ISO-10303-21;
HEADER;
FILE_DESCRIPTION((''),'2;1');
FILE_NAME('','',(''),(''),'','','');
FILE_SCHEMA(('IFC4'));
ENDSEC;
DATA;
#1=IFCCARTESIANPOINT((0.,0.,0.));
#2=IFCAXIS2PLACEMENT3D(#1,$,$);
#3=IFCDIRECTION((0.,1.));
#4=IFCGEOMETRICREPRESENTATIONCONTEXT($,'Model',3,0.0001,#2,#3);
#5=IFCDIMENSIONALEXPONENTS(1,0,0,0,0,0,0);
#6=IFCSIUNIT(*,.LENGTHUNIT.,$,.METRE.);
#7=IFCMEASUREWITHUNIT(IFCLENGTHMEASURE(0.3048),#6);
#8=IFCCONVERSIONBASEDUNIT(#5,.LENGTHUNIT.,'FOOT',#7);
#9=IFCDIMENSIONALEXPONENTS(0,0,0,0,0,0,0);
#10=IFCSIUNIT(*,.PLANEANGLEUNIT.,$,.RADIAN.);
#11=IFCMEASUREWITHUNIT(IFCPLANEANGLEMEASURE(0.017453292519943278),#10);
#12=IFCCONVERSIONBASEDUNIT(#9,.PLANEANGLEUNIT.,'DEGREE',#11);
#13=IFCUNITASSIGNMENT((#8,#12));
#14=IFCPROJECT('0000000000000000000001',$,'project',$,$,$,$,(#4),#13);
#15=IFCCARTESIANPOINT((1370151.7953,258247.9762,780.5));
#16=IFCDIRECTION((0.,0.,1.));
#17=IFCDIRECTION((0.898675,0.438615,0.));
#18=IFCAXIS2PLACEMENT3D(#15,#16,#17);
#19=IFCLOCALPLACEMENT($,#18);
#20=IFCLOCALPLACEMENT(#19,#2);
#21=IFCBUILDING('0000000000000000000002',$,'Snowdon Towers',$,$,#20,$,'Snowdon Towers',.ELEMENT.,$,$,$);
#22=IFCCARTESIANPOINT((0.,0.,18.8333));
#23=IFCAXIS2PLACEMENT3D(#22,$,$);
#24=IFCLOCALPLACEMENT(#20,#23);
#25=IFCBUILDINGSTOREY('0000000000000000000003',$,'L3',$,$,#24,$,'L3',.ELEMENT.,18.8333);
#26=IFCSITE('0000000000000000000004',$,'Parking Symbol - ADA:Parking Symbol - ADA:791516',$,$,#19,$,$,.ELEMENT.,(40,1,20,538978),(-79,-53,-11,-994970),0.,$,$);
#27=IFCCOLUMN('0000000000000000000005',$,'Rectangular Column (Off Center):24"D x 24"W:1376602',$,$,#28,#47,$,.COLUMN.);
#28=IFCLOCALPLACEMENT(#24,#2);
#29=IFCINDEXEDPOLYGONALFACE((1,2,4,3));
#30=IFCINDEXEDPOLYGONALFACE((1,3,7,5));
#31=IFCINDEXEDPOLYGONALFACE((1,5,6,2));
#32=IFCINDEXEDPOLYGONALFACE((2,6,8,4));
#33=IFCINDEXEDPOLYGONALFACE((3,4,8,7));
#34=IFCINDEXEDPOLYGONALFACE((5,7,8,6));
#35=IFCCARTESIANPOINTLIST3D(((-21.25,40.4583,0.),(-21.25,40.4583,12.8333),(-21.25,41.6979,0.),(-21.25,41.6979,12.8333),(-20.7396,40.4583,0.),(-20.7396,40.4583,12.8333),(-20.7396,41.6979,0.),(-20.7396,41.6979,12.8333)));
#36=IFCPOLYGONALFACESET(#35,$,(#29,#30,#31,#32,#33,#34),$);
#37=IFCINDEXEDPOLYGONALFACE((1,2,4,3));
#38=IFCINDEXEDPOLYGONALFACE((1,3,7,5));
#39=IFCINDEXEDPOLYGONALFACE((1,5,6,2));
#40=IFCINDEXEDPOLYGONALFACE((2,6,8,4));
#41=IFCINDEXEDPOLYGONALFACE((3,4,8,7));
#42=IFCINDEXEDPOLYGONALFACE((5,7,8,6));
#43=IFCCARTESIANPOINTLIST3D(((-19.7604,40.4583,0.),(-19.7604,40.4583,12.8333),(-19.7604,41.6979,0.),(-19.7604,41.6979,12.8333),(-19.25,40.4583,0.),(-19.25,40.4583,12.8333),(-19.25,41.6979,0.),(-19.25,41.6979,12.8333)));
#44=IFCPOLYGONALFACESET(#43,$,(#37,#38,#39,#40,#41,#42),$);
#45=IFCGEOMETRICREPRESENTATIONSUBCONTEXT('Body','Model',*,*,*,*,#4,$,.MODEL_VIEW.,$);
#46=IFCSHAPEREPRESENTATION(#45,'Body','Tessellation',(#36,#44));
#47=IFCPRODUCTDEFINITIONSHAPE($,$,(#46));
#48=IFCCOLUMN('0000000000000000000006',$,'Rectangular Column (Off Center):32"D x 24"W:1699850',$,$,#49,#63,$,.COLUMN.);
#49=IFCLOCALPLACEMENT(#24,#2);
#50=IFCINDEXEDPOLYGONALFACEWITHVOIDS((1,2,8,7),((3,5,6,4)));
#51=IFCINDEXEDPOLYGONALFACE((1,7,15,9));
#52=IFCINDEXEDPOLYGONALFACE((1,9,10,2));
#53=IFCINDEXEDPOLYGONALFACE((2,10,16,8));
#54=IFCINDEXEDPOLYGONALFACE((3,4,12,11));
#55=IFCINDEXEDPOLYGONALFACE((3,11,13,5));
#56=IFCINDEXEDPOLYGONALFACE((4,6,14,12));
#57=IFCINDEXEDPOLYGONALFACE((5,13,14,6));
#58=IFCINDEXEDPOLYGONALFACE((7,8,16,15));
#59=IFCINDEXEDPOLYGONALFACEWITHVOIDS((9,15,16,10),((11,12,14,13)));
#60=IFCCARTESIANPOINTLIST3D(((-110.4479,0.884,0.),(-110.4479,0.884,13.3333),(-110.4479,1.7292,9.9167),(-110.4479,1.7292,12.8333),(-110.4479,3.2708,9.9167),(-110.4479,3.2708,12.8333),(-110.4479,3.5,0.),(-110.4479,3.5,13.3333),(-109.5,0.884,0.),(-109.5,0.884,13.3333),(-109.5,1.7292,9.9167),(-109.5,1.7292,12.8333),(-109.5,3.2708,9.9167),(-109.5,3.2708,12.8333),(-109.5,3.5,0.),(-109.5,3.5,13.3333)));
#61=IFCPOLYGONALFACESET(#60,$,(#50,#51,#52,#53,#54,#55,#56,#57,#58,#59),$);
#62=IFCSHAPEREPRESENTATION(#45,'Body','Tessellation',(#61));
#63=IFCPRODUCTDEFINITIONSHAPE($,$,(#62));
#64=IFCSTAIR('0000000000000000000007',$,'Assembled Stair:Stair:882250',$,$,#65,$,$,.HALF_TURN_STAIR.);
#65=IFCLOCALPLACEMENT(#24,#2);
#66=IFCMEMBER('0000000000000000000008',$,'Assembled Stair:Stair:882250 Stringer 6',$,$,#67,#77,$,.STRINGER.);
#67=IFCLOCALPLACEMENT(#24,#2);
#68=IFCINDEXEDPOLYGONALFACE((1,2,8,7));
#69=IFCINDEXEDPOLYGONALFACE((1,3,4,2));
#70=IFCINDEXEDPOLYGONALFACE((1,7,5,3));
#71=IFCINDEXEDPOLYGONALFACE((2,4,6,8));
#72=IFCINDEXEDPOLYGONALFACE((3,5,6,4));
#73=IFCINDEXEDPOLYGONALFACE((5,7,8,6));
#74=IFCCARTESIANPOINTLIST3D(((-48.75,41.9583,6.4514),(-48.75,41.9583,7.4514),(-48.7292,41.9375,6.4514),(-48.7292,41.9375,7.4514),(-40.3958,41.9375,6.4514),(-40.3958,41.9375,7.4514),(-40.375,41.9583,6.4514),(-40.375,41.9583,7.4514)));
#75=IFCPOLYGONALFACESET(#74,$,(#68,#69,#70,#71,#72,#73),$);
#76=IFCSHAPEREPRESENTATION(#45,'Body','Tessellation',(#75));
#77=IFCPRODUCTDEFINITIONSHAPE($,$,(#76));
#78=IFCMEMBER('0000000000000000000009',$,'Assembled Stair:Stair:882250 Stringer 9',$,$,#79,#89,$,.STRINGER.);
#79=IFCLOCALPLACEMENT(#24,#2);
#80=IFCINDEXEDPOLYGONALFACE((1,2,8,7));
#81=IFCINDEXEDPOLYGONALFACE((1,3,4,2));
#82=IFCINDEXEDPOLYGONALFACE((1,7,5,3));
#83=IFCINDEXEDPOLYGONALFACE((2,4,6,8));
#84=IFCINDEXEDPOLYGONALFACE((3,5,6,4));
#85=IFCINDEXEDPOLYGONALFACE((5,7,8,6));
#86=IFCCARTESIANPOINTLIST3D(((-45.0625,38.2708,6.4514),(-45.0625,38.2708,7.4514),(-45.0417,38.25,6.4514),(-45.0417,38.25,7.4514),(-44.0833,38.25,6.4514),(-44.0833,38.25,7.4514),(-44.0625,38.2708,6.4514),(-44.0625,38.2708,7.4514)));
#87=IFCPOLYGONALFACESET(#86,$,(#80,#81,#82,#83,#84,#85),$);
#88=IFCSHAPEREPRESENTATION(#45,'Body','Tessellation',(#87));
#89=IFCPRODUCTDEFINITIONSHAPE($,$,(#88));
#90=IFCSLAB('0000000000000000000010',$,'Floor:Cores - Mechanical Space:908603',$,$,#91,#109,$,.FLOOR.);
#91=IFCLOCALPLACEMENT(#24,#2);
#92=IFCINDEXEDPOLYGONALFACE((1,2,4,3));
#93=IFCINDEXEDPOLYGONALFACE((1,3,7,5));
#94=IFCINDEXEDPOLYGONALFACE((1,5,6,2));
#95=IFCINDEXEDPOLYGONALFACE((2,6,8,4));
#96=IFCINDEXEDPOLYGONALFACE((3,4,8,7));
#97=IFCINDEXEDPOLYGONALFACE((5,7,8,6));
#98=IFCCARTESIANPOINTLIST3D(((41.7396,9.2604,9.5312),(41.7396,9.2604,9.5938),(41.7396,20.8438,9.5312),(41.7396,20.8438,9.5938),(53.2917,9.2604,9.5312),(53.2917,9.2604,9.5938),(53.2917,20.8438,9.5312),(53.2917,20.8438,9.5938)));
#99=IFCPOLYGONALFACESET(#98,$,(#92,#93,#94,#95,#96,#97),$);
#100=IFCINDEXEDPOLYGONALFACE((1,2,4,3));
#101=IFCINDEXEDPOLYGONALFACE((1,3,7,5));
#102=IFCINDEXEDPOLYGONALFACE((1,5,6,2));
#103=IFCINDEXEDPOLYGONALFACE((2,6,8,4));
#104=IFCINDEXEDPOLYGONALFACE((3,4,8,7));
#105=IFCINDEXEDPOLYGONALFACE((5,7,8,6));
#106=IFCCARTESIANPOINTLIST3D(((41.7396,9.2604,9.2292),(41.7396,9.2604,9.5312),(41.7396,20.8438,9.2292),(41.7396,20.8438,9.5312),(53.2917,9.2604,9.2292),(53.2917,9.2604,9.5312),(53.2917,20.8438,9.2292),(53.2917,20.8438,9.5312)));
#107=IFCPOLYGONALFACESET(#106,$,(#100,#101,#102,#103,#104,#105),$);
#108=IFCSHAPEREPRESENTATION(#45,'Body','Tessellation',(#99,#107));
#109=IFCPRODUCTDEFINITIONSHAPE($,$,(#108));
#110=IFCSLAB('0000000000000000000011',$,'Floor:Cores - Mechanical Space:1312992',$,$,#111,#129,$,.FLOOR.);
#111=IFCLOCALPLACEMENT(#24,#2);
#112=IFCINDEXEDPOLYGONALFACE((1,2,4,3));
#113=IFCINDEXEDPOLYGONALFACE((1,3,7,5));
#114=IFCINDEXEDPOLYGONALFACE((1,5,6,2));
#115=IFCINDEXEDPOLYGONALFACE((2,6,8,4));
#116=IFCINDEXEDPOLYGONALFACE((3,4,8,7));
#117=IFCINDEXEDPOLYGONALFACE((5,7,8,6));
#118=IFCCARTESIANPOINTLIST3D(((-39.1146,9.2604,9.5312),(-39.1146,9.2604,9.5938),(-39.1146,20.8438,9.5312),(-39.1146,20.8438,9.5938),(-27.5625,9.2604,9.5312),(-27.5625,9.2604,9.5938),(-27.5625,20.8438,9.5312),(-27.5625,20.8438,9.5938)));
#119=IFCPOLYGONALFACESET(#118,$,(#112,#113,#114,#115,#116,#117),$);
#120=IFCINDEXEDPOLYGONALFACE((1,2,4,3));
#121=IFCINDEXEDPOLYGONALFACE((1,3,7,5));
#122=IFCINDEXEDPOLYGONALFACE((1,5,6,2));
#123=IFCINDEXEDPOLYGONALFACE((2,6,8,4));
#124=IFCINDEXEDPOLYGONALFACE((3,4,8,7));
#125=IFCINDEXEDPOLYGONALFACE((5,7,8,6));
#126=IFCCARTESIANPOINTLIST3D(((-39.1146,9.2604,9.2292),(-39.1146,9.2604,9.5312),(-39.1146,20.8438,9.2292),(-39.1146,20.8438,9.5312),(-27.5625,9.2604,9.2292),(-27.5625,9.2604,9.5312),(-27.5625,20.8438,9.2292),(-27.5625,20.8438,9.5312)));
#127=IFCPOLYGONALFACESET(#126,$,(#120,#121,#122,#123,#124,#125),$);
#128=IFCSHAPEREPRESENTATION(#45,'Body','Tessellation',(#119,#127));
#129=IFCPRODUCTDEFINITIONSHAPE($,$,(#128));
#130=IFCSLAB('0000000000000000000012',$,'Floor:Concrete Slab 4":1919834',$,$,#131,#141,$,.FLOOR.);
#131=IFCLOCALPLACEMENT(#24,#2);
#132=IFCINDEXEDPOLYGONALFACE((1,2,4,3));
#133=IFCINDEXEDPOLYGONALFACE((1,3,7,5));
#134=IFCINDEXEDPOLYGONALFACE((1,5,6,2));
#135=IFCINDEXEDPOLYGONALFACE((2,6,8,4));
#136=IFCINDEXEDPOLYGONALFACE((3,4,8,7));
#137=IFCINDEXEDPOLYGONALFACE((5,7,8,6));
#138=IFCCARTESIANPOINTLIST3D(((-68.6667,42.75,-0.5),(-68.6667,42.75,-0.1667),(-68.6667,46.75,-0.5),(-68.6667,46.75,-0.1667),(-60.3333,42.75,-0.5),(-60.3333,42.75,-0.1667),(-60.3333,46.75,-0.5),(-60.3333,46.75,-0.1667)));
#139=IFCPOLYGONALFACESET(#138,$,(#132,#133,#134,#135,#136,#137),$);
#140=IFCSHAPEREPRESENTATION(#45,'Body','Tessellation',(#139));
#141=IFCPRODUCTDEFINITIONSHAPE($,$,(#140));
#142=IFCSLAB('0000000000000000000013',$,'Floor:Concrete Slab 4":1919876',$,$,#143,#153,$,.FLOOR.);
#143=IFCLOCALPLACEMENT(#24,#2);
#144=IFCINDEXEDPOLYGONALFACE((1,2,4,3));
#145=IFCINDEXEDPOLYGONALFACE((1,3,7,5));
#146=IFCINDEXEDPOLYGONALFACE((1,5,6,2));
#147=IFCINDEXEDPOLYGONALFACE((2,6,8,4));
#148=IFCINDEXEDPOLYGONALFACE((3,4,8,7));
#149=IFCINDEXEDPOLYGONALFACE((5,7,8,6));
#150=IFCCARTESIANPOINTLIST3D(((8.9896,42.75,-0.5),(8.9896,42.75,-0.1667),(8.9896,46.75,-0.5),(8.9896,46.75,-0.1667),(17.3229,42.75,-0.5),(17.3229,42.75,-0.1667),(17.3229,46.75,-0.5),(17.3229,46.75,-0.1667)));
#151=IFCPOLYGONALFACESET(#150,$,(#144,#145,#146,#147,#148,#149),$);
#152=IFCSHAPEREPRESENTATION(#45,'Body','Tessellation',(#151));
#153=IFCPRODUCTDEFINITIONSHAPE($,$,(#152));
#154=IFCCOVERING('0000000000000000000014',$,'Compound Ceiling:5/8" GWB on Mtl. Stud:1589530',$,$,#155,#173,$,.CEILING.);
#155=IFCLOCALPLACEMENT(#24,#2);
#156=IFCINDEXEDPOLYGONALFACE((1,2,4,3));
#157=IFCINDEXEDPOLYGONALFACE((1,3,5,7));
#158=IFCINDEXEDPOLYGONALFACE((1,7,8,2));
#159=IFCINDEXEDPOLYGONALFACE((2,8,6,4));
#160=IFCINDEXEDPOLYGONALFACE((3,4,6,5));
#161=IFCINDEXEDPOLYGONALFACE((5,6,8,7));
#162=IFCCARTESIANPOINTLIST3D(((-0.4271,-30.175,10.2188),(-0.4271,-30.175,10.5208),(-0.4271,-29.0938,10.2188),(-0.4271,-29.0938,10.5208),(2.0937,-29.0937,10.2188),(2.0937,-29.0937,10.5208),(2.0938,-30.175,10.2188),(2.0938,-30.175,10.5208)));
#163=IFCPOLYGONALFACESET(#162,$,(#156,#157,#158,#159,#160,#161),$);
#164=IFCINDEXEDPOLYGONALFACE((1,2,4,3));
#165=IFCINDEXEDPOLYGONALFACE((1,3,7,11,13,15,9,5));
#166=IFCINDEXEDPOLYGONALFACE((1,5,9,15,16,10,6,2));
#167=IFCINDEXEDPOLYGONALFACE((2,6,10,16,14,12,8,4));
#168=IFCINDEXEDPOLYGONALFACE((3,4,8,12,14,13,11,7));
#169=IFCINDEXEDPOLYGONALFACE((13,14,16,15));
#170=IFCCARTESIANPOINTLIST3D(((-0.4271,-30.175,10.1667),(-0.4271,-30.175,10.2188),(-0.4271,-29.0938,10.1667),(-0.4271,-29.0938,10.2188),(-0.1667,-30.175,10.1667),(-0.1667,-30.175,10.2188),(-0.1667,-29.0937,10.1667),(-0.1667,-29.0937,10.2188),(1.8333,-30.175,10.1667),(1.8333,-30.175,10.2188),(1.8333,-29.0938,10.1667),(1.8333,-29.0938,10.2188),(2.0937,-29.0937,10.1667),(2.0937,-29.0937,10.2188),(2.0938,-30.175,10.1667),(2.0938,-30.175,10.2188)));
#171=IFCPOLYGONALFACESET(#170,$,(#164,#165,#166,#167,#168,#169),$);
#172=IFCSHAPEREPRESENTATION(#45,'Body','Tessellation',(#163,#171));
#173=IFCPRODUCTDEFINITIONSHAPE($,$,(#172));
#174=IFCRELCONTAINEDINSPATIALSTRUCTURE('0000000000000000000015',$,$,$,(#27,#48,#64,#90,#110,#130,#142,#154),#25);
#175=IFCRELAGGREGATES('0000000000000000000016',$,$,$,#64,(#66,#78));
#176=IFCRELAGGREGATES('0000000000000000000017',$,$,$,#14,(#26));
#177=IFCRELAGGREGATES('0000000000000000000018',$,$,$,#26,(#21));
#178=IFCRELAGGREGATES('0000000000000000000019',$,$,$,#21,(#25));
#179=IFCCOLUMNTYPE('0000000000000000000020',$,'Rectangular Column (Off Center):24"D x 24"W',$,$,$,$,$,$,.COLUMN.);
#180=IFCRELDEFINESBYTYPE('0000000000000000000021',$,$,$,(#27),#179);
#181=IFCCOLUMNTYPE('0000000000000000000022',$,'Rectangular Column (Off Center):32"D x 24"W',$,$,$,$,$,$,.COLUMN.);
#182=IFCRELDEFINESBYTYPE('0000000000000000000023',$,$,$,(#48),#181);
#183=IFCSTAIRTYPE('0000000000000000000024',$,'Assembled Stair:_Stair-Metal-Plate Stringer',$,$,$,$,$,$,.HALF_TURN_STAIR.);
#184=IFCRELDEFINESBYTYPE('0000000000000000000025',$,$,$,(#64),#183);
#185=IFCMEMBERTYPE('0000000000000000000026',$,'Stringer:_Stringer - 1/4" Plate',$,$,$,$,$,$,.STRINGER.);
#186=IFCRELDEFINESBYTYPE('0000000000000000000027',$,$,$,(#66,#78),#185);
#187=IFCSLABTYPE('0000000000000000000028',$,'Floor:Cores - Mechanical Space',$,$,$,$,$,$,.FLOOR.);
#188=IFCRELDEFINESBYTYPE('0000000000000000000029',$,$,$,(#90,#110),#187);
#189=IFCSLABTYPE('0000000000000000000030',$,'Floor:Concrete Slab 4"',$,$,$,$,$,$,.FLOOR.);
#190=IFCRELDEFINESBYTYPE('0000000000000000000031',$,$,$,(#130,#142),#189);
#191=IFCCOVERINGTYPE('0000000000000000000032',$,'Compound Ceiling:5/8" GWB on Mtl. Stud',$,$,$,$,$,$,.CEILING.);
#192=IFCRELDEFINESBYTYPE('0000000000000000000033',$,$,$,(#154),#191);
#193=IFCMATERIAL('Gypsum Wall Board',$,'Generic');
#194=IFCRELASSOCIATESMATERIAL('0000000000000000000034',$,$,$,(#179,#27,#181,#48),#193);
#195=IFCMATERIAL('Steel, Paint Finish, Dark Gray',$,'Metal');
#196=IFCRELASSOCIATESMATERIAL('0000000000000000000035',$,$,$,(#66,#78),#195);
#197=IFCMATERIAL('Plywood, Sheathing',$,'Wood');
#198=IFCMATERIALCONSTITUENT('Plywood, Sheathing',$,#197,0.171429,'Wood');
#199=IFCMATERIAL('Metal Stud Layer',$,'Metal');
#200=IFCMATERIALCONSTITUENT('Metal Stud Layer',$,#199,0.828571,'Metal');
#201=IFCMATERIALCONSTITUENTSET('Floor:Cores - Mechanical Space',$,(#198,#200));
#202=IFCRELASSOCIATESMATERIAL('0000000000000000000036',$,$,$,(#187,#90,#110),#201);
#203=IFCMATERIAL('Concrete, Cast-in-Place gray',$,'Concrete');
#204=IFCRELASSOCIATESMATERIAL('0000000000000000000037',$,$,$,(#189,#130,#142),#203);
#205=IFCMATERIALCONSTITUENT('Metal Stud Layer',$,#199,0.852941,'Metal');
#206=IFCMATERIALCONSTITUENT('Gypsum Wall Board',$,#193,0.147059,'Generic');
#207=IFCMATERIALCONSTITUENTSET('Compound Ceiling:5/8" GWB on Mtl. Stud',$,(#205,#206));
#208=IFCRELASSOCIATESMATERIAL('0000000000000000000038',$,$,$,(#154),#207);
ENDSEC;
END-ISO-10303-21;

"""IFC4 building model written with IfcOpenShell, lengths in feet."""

from ifc_helpers import new_model, entity, si_unit, converted_unit, direction, frame, origin, place, context, subcontext, project, spatial, indexed_curve, outline, extrude, source, transform, mapped, material, constituent, constituent_set, type_object, type_shapes, element, aggregate, save


model = new_model("IFC4")

# Units and contexts
model_context = context("Model", 3, precision=0.0001, world=origin(), true_north=direction((0.0, 1.0)))
body_context = subcontext(model_context, "Body", "Model", "MODEL_VIEW")
ifc_project = project(units=[converted_unit("LENGTHUNIT", "FOOT", entity("IfcLengthMeasure", 0.3048), si_unit("LENGTHUNIT", "METRE"), dimensions=[1, 0, 0, 0, 0, 0, 0]), converted_unit("PLANEANGLEUNIT", "DEGREE", entity("IfcPlaneAngleMeasure", 0.017453292519943278), si_unit("PLANEANGLEUNIT", "RADIAN"), dimensions=[0, 0, 0, 0, 0, 0, 0])], contexts=[model_context])

# Site, building, storey
site_placement = place(None, frame((1370151.7953, 258247.9762, 780.5), z_axis=(0.0, 0.0, 1.0), x_axis=(0.898675, 0.438615, 0.0)))
site = spatial("IfcSite", under=ifc_project, at=site_placement, Name="Parking Symbol - ADA:Parking Symbol - ADA:791516", CompositionType="ELEMENT", RefLatitude=(40, 1, 20, 538978), RefLongitude=(-79, -53, -11, -994970), RefElevation=0.0)
building_placement = place(site_placement, origin())
building = spatial("IfcBuilding", under=site, at=building_placement, Name="Snowdon Towers", LongName="Snowdon Towers", CompositionType="ELEMENT")
storey_placement = place(building_placement, frame((0.0, 0.0, 18.8333)))
storey = spatial("IfcBuildingStorey", under=building, at=storey_placement, Name="L3", LongName="L3", CompositionType="ELEMENT", Elevation=18.8333)

# Column
ifc_material_1 = material(Name="Gypsum Wall Board", Category="Generic")
column_type_1 = type_object("IfcColumnType", Name="Rectangular Column (Off Center):24\"D x 24\"W", PredefinedType="COLUMN", material=ifc_material_1)
shared_shape_1 = source(origin(), body_context, "Body", "SweptSolid", [
    extrude(outline(indexed_curve([(-0.6198, -0.2552), (0.6198, -0.2552), (0.6198, 0.2552), (-0.6198, 0.2552), (-0.6198, -0.2552)], self_intersect=False)), frame((-20.9948, 41.0781, 18.8333), z_axis=(0.0, 0.0, 1.0), x_axis=(0.0, 1.0, 0.0)), (0.0, 0.0, 1.0), 12.8333),
    extrude(outline(indexed_curve([(-0.6198, -0.2552), (0.6198, -0.2552), (0.6198, 0.2552), (-0.6198, 0.2552), (-0.6198, -0.2552)], self_intersect=False)), frame((-19.5052, 41.0781, 18.8333), z_axis=(0.0, 0.0, 1.0), x_axis=(0.0, 1.0, 0.0)), (0.0, 0.0, 1.0), 12.8333),
])
type_shapes(column_type_1, [shared_shape_1])
column_1_placement = place(storey_placement, frame((0.0, 0.0, -18.8333)))
element("IfcColumn", 1, at=column_1_placement, inside=storey, type_object=column_type_1, material=ifc_material_1, Name="Rectangular Column (Off Center):24\"D x 24\"W:1376602", PredefinedType="COLUMN", context=body_context, shape_type="MappedRepresentation", body=[
    mapped(shared_shape_1, transform((0.0, 0.0, 0.0), scale=1.0)),
])

# Column, opening
column_type_2 = type_object("IfcColumnType", Name="Rectangular Column (Off Center):32\"D x 24\"W", PredefinedType="COLUMN", material=ifc_material_1)
shared_shape_2 = source(origin(), body_context, "Body", "SweptSolid", [
    extrude(outline(indexed_curve([(-1.308, -0.474), (1.308, -0.474), (1.308, 0.474), (-1.308, 0.474), (-1.308, -0.474)], self_intersect=False)), frame((-109.974, 2.192, 18.8333), z_axis=(0.0, 0.0, 1.0), x_axis=(0.0, -1.0, 0.0)), (0.0, 0.0, 1.0), 13.3333),
])
type_shapes(column_type_2, [shared_shape_2])
column_2_placement = place(storey_placement, frame((0.0, 0.0, -18.8333)))
column_2 = element("IfcColumn", 2, at=column_2_placement, inside=storey, type_object=column_type_2, material=ifc_material_1, Name="Rectangular Column (Off Center):32\"D x 24\"W:1699850", PredefinedType="COLUMN", context=body_context, shape_type="MappedRepresentation", body=[
    mapped(shared_shape_2, transform((0.0, 0.0, 0.0), scale=1.0)),
])
opening_1_placement = place(storey_placement, frame((0.0, 0.0, -18.8333)))
element("IfcOpeningElement", 3, at=opening_1_placement, cuts=column_2, PredefinedType="OPENING", context=body_context, shape_type="SweptSolid", body=[
    extrude(outline(indexed_curve([(-1.4583, -0.7708), (1.4583, -0.7708), (1.4583, 0.7708), (-1.4583, 0.7708), (-1.4583, -0.7708)], self_intersect=False)), frame((-110.4479, 2.5, 30.2083), z_axis=(1.0, 0.0, 0.0), x_axis=(0.0, 0.0, 1.0)), (0.0, 0.0, 1.0), 0.9479),
])

# Stair, members
stair_type = type_object("IfcStairType", Name="Assembled Stair:_Stair-Metal-Plate Stringer", PredefinedType="HALF_TURN_STAIR")
stair_placement = place(storey_placement, origin())
stair = element("IfcStair", 4, at=stair_placement, inside=storey, type_object=stair_type, Name="Assembled Stair:Stair:882250", PredefinedType="HALF_TURN_STAIR")
ifc_material_2 = material(Name="Steel, Paint Finish, Dark Gray", Category="Metal")
member_type = type_object("IfcMemberType", Name="Stringer:_Stringer - 1/4\" Plate", PredefinedType="STRINGER")
member_1_placement = place(stair_placement, origin())
member_1 = element("IfcMember", 5, at=member_1_placement, type_object=member_type, material=ifc_material_2, Name="Assembled Stair:Stair:882250 Stringer 6", PredefinedType="STRINGER", context=body_context, shape_type="SweptSolid", body=[
    extrude(outline(indexed_curve([(-4.1875, -0.0104), (4.1875, -0.0104), (4.1667, 0.0104), (-4.1667, 0.0104), (-4.1875, -0.0104)], self_intersect=False)), frame((-44.5625, 41.9479, 6.4514), z_axis=(0.0, 0.0, 1.0), x_axis=(-1.0, 0.0, 0.0)), (0.0, 0.0, 1.0), 1.0),
])
member_2_placement = place(stair_placement, origin())
member_2 = element("IfcMember", 6, at=member_2_placement, type_object=member_type, material=ifc_material_2, Name="Assembled Stair:Stair:882250 Stringer 9", PredefinedType="STRINGER", context=body_context, shape_type="SweptSolid", body=[
    extrude(outline(indexed_curve([(-0.4792, -0.0104), (0.4792, -0.0104), (0.5, 0.0104), (-0.5, 0.0104), (-0.4792, -0.0104)], self_intersect=False)), frame((-44.5625, 38.2604, 6.4514)), (0.0, 0.0, 1.0), 1.0),
])
aggregate(stair, [member_1, member_2])

# Slabs
ifc_material_3 = material(Name="Plywood, Sheathing", Category="Wood")
ifc_constituent_1 = constituent(ifc_material_3, Name="Plywood, Sheathing", Category="Wood", fraction=0.171429)
ifc_material_4 = material(Name="Metal Stud Layer", Category="Metal")
ifc_constituent_2 = constituent(ifc_material_4, Name="Metal Stud Layer", Category="Metal", fraction=0.828571)
ifc_constituent_set_1 = constituent_set(constituents=[ifc_constituent_1, ifc_constituent_2], Name="Floor:Cores - Mechanical Space")
slab_type_1 = type_object("IfcSlabType", Name="Floor:Cores - Mechanical Space", PredefinedType="FLOOR", material=ifc_constituent_set_1)
slab_1_placement = place(storey_placement, origin())
element("IfcSlab", 7, at=slab_1_placement, inside=storey, type_object=slab_type_1, material=ifc_constituent_set_1, Name="Floor:Cores - Mechanical Space:908603", PredefinedType="FLOOR", context=body_context, shape_type="SweptSolid", body=[
    extrude(outline(indexed_curve([(-5.7917, -5.776), (5.7917, -5.776), (5.7917, 5.776), (-5.7917, 5.776), (-5.7917, -5.776)], self_intersect=False)), frame((47.5156, 15.0521, 9.5312), z_axis=(0.0, 0.0, 1.0), x_axis=(0.0, 1.0, 0.0)), (0.0, 0.0, 1.0), 0.0625),
    extrude(outline(indexed_curve([(-5.7917, -5.776), (5.7917, -5.776), (5.7917, 5.776), (-5.7917, 5.776), (-5.7917, -5.776)], self_intersect=False)), frame((47.5156, 15.0521, 9.2292), z_axis=(0.0, 0.0, 1.0), x_axis=(0.0, 1.0, 0.0)), (0.0, 0.0, 1.0), 0.3021),
])
slab_2_placement = place(storey_placement, origin())
element("IfcSlab", 8, at=slab_2_placement, inside=storey, type_object=slab_type_1, material=ifc_constituent_set_1, Name="Floor:Cores - Mechanical Space:1312992", PredefinedType="FLOOR", context=body_context, shape_type="SweptSolid", body=[
    extrude(outline(indexed_curve([(-5.7917, -5.776), (5.7917, -5.776), (5.7917, 5.776), (-5.7917, 5.776), (-5.7917, -5.776)], self_intersect=False)), frame((-33.3385, 15.0521, 9.5312), z_axis=(0.0, 0.0, 1.0), x_axis=(0.0, 1.0, 0.0)), (0.0, 0.0, 1.0), 0.0625),
    extrude(outline(indexed_curve([(-5.7917, -5.776), (5.7917, -5.776), (5.7917, 5.776), (-5.7917, 5.776), (-5.7917, -5.776)], self_intersect=False)), frame((-33.3385, 15.0521, 9.2292), z_axis=(0.0, 0.0, 1.0), x_axis=(0.0, 1.0, 0.0)), (0.0, 0.0, 1.0), 0.3021),
])

# Slabs
ifc_material_5 = material(Name="Concrete, Cast-in-Place gray", Category="Concrete")
slab_type_2 = type_object("IfcSlabType", Name="Floor:Concrete Slab 4\"", PredefinedType="FLOOR", material=ifc_material_5)
slab_3_placement = place(storey_placement, origin())
element("IfcSlab", 9, at=slab_3_placement, inside=storey, type_object=slab_type_2, material=ifc_material_5, Name="Floor:Concrete Slab 4\":1919834", PredefinedType="FLOOR", context=body_context, shape_type="SweptSolid", body=[
    extrude(outline(indexed_curve([(-2.0, -4.1667), (2.0, -4.1667), (2.0, 4.1667), (-2.0, 4.1667), (-2.0, -4.1667)], self_intersect=False)), frame((-64.5, 44.75, -0.1667), z_axis=(0.0, 0.0, -1.0), x_axis=(0.0, 1.0, 0.0)), (0.0, 0.0, 1.0), 0.3333),
])
slab_4_placement = place(storey_placement, origin())
element("IfcSlab", 10, at=slab_4_placement, inside=storey, type_object=slab_type_2, material=ifc_material_5, Name="Floor:Concrete Slab 4\":1919876", PredefinedType="FLOOR", context=body_context, shape_type="SweptSolid", body=[
    extrude(outline(indexed_curve([(-2.0, -4.1667), (2.0, -4.1667), (2.0, 4.1667), (-2.0, 4.1667), (-2.0, -4.1667)], self_intersect=False)), frame((13.1563, 44.75, -0.1667), z_axis=(0.0, 0.0, -1.0), x_axis=(0.0, 1.0, 0.0)), (0.0, 0.0, 1.0), 0.3333),
])

# Covering
ifc_constituent_3 = constituent(ifc_material_4, Name="Metal Stud Layer", Category="Metal", fraction=0.852941)
ifc_constituent_4 = constituent(ifc_material_1, Name="Gypsum Wall Board", Category="Generic", fraction=0.147059)
ifc_constituent_set_2 = constituent_set(constituents=[ifc_constituent_3, ifc_constituent_4], Name="Compound Ceiling:5/8\" GWB on Mtl. Stud")
covering_type_1 = type_object("IfcCoveringType", Name="Compound Ceiling:5/8\" GWB on Mtl. Stud", PredefinedType="CEILING")
covering_1_placement = place(storey_placement, origin())
element("IfcCovering", 11, at=covering_1_placement, inside=storey, type_object=covering_type_1, material=ifc_constituent_set_2, Name="Compound Ceiling:5/8\" GWB on Mtl. Stud:1589530", PredefinedType="CEILING", context=body_context, shape_type="SweptSolid", body=[
    extrude(outline(indexed_curve([(-0.5406, -1.2604), (0.5406, -1.2604), (0.5406, 1.2604), (-0.5406, 1.2604), (-0.5406, -1.2604)], self_intersect=False)), frame((0.8333, -29.6344, 10.2188), z_axis=(0.0, 0.0, 1.0), x_axis=(0.0, 1.0, 0.0)), (0.0, 0.0, 1.0), 0.3021),
    extrude(outline(indexed_curve([(-1.2604, -0.5406), (-1.0, -0.5406), (1.0, -0.5406), (1.2604, -0.5406), (1.2604, 0.5406), (1.0, 0.5406), (-1.0, 0.5406), (-1.2604, 0.5406), (-1.2604, -0.5406)], self_intersect=False)), frame((0.8333, -29.6344, 10.1667), z_axis=(0.0, 0.0, 1.0), x_axis=(-1.0, 0.0, 0.0)), (0.0, 0.0, 1.0), 0.0521),
])

save(model, "model.ifc")
